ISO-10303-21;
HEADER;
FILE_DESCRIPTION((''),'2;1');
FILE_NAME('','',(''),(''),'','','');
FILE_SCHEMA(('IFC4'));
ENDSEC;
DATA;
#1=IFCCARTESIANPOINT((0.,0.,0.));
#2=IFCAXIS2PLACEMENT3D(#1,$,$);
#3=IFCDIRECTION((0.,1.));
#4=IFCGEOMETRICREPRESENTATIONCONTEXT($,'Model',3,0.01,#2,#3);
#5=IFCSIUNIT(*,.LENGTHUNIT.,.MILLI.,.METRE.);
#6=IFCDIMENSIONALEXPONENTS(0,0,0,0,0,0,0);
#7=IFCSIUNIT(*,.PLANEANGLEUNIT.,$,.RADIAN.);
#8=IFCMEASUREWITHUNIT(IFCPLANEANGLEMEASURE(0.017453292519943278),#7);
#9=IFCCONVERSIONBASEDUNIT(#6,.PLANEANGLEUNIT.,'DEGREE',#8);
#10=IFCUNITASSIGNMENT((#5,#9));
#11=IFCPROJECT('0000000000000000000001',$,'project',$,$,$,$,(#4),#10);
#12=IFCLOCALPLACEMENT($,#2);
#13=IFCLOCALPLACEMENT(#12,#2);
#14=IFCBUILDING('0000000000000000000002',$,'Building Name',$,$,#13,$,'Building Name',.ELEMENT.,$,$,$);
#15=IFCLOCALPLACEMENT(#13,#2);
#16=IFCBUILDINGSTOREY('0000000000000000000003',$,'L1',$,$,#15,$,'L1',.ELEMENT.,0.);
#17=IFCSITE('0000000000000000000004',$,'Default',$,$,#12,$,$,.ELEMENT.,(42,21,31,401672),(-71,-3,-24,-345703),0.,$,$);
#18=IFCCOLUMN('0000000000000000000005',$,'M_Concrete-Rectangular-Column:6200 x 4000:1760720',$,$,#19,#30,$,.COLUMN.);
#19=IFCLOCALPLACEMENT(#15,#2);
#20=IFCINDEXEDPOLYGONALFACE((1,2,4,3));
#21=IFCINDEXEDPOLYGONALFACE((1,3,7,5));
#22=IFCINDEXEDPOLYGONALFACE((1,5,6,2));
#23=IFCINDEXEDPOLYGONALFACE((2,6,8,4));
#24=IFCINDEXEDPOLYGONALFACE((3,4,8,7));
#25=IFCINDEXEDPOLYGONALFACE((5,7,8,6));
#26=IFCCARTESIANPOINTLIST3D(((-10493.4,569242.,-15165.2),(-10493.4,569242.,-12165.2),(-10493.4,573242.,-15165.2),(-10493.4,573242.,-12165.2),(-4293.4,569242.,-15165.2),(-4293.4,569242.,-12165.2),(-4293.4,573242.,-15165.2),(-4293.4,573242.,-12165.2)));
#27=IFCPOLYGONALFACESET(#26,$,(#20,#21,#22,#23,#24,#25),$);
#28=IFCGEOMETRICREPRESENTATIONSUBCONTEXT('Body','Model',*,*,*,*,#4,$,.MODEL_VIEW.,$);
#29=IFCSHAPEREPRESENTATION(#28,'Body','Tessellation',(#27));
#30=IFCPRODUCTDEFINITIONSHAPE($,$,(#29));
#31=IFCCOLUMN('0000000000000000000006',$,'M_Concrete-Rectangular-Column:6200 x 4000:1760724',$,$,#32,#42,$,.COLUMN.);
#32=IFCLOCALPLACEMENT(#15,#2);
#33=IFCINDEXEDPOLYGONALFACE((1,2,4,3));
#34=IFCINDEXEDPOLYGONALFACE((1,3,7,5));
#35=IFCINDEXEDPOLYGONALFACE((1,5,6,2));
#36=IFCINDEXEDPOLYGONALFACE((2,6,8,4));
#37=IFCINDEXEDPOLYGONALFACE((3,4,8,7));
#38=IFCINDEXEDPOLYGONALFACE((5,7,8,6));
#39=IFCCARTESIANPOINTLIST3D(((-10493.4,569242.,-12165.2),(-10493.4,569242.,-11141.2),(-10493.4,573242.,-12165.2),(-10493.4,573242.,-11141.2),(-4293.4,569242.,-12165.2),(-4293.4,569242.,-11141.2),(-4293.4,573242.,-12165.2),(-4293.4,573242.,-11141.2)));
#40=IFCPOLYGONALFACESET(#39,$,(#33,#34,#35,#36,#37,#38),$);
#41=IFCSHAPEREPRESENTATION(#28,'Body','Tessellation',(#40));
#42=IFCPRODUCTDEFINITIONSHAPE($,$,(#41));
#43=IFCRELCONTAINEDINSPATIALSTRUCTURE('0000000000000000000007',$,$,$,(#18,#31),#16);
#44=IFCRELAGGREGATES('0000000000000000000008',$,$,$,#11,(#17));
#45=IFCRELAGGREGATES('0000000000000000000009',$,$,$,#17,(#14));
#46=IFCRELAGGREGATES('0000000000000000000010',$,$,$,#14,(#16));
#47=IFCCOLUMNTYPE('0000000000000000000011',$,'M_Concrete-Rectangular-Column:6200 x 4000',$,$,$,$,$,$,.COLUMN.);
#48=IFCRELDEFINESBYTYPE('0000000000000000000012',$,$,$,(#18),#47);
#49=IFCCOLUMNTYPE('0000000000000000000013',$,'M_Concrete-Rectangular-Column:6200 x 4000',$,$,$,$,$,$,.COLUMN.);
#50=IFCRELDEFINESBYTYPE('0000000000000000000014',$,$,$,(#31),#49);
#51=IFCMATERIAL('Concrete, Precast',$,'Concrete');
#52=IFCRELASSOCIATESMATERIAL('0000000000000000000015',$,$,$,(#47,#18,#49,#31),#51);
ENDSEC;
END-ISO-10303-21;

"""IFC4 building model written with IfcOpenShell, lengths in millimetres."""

from ifc_helpers import new_model, entity, si_unit, converted_unit, direction, frame, origin, place, context, subcontext, project, spatial, indexed_curve, outline, extrude, source, transform, mapped, material, type_object, type_shapes, element, save


model = new_model("IFC4")

# Units and contexts
model_context = context("Model", 3, precision=0.01, world=origin(), true_north=direction((0.0, 1.0)))
body_context = subcontext(model_context, "Body", "Model", "MODEL_VIEW")
ifc_project = project(units=[si_unit("LENGTHUNIT", "METRE", prefix="MILLI"), converted_unit("PLANEANGLEUNIT", "DEGREE", entity("IfcPlaneAngleMeasure", 0.017453292519943278), si_unit("PLANEANGLEUNIT", "RADIAN"), dimensions=[0, 0, 0, 0, 0, 0, 0])], contexts=[model_context])

# Site, building, storey
site_placement = place(None, origin())
site = spatial("IfcSite", under=ifc_project, at=site_placement, Name="Default", CompositionType="ELEMENT", RefLatitude=(42, 21, 31, 401672), RefLongitude=(-71, -3, -24, -345703), RefElevation=0.0)
building_placement = place(site_placement, origin())
building = spatial("IfcBuilding", under=site, at=building_placement, Name="Building Name", LongName="Building Name", CompositionType="ELEMENT")
storey_placement = place(building_placement, origin())
storey = spatial("IfcBuildingStorey", under=building, at=storey_placement, Name="L1", LongName="L1", CompositionType="ELEMENT", Elevation=0.0)

# Columns
ifc_material_1 = material(Name="Concrete, Precast", Category="Concrete")
column_type_1 = type_object("IfcColumnType", Name="M_Concrete-Rectangular-Column:6200 x 4000", PredefinedType="COLUMN", material=ifc_material_1)
shared_shape_1 = source(origin(), body_context, "Body", "SweptSolid", [
    extrude(outline(indexed_curve([(-2000.0, -3100.0), (2000.0, -3100.0), (2000.0, 3100.0), (-2000.0, 3100.0), (-2000.0, -3100.0)], self_intersect=False)), frame((-7393.4, 571242.0, -15165.2), z_axis=(0.0, 0.0, 1.0), x_axis=(0.0, -1.0, 0.0)), (0.0, 0.0, 1.0), 3000.0),
])
type_shapes(column_type_1, [shared_shape_1])
column_1_placement = place(storey_placement, origin())
element("IfcColumn", 1, at=column_1_placement, inside=storey, type_object=column_type_1, material=ifc_material_1, Name="M_Concrete-Rectangular-Column:6200 x 4000:1760720", PredefinedType="COLUMN", context=body_context, shape_type="MappedRepresentation", body=[
    mapped(shared_shape_1, transform((0.0, 0.0, 0.0), scale=1.0)),
])
column_type_2 = type_object("IfcColumnType", Name="M_Concrete-Rectangular-Column:6200 x 4000", PredefinedType="COLUMN", material=ifc_material_1)
shared_shape_2 = source(origin(), body_context, "Body", "SweptSolid", [
    extrude(outline(indexed_curve([(-2000.0, -3100.0), (2000.0, -3100.0), (2000.0, 3100.0), (-2000.0, 3100.0), (-2000.0, -3100.0)], self_intersect=False)), frame((-7393.4, 571242.0, -12165.2), z_axis=(0.0, 0.0, 1.0), x_axis=(0.0, -1.0, 0.0)), (0.0, 0.0, 1.0), 1024.0),
])
type_shapes(column_type_2, [shared_shape_2])
column_2_placement = place(storey_placement, origin())
element("IfcColumn", 2, at=column_2_placement, inside=storey, type_object=column_type_2, material=ifc_material_1, Name="M_Concrete-Rectangular-Column:6200 x 4000:1760724", PredefinedType="COLUMN", context=body_context, shape_type="MappedRepresentation", body=[
    mapped(shared_shape_2, transform((0.0, 0.0, 0.0), scale=1.0)),
])

save(model, "model.ifc")
